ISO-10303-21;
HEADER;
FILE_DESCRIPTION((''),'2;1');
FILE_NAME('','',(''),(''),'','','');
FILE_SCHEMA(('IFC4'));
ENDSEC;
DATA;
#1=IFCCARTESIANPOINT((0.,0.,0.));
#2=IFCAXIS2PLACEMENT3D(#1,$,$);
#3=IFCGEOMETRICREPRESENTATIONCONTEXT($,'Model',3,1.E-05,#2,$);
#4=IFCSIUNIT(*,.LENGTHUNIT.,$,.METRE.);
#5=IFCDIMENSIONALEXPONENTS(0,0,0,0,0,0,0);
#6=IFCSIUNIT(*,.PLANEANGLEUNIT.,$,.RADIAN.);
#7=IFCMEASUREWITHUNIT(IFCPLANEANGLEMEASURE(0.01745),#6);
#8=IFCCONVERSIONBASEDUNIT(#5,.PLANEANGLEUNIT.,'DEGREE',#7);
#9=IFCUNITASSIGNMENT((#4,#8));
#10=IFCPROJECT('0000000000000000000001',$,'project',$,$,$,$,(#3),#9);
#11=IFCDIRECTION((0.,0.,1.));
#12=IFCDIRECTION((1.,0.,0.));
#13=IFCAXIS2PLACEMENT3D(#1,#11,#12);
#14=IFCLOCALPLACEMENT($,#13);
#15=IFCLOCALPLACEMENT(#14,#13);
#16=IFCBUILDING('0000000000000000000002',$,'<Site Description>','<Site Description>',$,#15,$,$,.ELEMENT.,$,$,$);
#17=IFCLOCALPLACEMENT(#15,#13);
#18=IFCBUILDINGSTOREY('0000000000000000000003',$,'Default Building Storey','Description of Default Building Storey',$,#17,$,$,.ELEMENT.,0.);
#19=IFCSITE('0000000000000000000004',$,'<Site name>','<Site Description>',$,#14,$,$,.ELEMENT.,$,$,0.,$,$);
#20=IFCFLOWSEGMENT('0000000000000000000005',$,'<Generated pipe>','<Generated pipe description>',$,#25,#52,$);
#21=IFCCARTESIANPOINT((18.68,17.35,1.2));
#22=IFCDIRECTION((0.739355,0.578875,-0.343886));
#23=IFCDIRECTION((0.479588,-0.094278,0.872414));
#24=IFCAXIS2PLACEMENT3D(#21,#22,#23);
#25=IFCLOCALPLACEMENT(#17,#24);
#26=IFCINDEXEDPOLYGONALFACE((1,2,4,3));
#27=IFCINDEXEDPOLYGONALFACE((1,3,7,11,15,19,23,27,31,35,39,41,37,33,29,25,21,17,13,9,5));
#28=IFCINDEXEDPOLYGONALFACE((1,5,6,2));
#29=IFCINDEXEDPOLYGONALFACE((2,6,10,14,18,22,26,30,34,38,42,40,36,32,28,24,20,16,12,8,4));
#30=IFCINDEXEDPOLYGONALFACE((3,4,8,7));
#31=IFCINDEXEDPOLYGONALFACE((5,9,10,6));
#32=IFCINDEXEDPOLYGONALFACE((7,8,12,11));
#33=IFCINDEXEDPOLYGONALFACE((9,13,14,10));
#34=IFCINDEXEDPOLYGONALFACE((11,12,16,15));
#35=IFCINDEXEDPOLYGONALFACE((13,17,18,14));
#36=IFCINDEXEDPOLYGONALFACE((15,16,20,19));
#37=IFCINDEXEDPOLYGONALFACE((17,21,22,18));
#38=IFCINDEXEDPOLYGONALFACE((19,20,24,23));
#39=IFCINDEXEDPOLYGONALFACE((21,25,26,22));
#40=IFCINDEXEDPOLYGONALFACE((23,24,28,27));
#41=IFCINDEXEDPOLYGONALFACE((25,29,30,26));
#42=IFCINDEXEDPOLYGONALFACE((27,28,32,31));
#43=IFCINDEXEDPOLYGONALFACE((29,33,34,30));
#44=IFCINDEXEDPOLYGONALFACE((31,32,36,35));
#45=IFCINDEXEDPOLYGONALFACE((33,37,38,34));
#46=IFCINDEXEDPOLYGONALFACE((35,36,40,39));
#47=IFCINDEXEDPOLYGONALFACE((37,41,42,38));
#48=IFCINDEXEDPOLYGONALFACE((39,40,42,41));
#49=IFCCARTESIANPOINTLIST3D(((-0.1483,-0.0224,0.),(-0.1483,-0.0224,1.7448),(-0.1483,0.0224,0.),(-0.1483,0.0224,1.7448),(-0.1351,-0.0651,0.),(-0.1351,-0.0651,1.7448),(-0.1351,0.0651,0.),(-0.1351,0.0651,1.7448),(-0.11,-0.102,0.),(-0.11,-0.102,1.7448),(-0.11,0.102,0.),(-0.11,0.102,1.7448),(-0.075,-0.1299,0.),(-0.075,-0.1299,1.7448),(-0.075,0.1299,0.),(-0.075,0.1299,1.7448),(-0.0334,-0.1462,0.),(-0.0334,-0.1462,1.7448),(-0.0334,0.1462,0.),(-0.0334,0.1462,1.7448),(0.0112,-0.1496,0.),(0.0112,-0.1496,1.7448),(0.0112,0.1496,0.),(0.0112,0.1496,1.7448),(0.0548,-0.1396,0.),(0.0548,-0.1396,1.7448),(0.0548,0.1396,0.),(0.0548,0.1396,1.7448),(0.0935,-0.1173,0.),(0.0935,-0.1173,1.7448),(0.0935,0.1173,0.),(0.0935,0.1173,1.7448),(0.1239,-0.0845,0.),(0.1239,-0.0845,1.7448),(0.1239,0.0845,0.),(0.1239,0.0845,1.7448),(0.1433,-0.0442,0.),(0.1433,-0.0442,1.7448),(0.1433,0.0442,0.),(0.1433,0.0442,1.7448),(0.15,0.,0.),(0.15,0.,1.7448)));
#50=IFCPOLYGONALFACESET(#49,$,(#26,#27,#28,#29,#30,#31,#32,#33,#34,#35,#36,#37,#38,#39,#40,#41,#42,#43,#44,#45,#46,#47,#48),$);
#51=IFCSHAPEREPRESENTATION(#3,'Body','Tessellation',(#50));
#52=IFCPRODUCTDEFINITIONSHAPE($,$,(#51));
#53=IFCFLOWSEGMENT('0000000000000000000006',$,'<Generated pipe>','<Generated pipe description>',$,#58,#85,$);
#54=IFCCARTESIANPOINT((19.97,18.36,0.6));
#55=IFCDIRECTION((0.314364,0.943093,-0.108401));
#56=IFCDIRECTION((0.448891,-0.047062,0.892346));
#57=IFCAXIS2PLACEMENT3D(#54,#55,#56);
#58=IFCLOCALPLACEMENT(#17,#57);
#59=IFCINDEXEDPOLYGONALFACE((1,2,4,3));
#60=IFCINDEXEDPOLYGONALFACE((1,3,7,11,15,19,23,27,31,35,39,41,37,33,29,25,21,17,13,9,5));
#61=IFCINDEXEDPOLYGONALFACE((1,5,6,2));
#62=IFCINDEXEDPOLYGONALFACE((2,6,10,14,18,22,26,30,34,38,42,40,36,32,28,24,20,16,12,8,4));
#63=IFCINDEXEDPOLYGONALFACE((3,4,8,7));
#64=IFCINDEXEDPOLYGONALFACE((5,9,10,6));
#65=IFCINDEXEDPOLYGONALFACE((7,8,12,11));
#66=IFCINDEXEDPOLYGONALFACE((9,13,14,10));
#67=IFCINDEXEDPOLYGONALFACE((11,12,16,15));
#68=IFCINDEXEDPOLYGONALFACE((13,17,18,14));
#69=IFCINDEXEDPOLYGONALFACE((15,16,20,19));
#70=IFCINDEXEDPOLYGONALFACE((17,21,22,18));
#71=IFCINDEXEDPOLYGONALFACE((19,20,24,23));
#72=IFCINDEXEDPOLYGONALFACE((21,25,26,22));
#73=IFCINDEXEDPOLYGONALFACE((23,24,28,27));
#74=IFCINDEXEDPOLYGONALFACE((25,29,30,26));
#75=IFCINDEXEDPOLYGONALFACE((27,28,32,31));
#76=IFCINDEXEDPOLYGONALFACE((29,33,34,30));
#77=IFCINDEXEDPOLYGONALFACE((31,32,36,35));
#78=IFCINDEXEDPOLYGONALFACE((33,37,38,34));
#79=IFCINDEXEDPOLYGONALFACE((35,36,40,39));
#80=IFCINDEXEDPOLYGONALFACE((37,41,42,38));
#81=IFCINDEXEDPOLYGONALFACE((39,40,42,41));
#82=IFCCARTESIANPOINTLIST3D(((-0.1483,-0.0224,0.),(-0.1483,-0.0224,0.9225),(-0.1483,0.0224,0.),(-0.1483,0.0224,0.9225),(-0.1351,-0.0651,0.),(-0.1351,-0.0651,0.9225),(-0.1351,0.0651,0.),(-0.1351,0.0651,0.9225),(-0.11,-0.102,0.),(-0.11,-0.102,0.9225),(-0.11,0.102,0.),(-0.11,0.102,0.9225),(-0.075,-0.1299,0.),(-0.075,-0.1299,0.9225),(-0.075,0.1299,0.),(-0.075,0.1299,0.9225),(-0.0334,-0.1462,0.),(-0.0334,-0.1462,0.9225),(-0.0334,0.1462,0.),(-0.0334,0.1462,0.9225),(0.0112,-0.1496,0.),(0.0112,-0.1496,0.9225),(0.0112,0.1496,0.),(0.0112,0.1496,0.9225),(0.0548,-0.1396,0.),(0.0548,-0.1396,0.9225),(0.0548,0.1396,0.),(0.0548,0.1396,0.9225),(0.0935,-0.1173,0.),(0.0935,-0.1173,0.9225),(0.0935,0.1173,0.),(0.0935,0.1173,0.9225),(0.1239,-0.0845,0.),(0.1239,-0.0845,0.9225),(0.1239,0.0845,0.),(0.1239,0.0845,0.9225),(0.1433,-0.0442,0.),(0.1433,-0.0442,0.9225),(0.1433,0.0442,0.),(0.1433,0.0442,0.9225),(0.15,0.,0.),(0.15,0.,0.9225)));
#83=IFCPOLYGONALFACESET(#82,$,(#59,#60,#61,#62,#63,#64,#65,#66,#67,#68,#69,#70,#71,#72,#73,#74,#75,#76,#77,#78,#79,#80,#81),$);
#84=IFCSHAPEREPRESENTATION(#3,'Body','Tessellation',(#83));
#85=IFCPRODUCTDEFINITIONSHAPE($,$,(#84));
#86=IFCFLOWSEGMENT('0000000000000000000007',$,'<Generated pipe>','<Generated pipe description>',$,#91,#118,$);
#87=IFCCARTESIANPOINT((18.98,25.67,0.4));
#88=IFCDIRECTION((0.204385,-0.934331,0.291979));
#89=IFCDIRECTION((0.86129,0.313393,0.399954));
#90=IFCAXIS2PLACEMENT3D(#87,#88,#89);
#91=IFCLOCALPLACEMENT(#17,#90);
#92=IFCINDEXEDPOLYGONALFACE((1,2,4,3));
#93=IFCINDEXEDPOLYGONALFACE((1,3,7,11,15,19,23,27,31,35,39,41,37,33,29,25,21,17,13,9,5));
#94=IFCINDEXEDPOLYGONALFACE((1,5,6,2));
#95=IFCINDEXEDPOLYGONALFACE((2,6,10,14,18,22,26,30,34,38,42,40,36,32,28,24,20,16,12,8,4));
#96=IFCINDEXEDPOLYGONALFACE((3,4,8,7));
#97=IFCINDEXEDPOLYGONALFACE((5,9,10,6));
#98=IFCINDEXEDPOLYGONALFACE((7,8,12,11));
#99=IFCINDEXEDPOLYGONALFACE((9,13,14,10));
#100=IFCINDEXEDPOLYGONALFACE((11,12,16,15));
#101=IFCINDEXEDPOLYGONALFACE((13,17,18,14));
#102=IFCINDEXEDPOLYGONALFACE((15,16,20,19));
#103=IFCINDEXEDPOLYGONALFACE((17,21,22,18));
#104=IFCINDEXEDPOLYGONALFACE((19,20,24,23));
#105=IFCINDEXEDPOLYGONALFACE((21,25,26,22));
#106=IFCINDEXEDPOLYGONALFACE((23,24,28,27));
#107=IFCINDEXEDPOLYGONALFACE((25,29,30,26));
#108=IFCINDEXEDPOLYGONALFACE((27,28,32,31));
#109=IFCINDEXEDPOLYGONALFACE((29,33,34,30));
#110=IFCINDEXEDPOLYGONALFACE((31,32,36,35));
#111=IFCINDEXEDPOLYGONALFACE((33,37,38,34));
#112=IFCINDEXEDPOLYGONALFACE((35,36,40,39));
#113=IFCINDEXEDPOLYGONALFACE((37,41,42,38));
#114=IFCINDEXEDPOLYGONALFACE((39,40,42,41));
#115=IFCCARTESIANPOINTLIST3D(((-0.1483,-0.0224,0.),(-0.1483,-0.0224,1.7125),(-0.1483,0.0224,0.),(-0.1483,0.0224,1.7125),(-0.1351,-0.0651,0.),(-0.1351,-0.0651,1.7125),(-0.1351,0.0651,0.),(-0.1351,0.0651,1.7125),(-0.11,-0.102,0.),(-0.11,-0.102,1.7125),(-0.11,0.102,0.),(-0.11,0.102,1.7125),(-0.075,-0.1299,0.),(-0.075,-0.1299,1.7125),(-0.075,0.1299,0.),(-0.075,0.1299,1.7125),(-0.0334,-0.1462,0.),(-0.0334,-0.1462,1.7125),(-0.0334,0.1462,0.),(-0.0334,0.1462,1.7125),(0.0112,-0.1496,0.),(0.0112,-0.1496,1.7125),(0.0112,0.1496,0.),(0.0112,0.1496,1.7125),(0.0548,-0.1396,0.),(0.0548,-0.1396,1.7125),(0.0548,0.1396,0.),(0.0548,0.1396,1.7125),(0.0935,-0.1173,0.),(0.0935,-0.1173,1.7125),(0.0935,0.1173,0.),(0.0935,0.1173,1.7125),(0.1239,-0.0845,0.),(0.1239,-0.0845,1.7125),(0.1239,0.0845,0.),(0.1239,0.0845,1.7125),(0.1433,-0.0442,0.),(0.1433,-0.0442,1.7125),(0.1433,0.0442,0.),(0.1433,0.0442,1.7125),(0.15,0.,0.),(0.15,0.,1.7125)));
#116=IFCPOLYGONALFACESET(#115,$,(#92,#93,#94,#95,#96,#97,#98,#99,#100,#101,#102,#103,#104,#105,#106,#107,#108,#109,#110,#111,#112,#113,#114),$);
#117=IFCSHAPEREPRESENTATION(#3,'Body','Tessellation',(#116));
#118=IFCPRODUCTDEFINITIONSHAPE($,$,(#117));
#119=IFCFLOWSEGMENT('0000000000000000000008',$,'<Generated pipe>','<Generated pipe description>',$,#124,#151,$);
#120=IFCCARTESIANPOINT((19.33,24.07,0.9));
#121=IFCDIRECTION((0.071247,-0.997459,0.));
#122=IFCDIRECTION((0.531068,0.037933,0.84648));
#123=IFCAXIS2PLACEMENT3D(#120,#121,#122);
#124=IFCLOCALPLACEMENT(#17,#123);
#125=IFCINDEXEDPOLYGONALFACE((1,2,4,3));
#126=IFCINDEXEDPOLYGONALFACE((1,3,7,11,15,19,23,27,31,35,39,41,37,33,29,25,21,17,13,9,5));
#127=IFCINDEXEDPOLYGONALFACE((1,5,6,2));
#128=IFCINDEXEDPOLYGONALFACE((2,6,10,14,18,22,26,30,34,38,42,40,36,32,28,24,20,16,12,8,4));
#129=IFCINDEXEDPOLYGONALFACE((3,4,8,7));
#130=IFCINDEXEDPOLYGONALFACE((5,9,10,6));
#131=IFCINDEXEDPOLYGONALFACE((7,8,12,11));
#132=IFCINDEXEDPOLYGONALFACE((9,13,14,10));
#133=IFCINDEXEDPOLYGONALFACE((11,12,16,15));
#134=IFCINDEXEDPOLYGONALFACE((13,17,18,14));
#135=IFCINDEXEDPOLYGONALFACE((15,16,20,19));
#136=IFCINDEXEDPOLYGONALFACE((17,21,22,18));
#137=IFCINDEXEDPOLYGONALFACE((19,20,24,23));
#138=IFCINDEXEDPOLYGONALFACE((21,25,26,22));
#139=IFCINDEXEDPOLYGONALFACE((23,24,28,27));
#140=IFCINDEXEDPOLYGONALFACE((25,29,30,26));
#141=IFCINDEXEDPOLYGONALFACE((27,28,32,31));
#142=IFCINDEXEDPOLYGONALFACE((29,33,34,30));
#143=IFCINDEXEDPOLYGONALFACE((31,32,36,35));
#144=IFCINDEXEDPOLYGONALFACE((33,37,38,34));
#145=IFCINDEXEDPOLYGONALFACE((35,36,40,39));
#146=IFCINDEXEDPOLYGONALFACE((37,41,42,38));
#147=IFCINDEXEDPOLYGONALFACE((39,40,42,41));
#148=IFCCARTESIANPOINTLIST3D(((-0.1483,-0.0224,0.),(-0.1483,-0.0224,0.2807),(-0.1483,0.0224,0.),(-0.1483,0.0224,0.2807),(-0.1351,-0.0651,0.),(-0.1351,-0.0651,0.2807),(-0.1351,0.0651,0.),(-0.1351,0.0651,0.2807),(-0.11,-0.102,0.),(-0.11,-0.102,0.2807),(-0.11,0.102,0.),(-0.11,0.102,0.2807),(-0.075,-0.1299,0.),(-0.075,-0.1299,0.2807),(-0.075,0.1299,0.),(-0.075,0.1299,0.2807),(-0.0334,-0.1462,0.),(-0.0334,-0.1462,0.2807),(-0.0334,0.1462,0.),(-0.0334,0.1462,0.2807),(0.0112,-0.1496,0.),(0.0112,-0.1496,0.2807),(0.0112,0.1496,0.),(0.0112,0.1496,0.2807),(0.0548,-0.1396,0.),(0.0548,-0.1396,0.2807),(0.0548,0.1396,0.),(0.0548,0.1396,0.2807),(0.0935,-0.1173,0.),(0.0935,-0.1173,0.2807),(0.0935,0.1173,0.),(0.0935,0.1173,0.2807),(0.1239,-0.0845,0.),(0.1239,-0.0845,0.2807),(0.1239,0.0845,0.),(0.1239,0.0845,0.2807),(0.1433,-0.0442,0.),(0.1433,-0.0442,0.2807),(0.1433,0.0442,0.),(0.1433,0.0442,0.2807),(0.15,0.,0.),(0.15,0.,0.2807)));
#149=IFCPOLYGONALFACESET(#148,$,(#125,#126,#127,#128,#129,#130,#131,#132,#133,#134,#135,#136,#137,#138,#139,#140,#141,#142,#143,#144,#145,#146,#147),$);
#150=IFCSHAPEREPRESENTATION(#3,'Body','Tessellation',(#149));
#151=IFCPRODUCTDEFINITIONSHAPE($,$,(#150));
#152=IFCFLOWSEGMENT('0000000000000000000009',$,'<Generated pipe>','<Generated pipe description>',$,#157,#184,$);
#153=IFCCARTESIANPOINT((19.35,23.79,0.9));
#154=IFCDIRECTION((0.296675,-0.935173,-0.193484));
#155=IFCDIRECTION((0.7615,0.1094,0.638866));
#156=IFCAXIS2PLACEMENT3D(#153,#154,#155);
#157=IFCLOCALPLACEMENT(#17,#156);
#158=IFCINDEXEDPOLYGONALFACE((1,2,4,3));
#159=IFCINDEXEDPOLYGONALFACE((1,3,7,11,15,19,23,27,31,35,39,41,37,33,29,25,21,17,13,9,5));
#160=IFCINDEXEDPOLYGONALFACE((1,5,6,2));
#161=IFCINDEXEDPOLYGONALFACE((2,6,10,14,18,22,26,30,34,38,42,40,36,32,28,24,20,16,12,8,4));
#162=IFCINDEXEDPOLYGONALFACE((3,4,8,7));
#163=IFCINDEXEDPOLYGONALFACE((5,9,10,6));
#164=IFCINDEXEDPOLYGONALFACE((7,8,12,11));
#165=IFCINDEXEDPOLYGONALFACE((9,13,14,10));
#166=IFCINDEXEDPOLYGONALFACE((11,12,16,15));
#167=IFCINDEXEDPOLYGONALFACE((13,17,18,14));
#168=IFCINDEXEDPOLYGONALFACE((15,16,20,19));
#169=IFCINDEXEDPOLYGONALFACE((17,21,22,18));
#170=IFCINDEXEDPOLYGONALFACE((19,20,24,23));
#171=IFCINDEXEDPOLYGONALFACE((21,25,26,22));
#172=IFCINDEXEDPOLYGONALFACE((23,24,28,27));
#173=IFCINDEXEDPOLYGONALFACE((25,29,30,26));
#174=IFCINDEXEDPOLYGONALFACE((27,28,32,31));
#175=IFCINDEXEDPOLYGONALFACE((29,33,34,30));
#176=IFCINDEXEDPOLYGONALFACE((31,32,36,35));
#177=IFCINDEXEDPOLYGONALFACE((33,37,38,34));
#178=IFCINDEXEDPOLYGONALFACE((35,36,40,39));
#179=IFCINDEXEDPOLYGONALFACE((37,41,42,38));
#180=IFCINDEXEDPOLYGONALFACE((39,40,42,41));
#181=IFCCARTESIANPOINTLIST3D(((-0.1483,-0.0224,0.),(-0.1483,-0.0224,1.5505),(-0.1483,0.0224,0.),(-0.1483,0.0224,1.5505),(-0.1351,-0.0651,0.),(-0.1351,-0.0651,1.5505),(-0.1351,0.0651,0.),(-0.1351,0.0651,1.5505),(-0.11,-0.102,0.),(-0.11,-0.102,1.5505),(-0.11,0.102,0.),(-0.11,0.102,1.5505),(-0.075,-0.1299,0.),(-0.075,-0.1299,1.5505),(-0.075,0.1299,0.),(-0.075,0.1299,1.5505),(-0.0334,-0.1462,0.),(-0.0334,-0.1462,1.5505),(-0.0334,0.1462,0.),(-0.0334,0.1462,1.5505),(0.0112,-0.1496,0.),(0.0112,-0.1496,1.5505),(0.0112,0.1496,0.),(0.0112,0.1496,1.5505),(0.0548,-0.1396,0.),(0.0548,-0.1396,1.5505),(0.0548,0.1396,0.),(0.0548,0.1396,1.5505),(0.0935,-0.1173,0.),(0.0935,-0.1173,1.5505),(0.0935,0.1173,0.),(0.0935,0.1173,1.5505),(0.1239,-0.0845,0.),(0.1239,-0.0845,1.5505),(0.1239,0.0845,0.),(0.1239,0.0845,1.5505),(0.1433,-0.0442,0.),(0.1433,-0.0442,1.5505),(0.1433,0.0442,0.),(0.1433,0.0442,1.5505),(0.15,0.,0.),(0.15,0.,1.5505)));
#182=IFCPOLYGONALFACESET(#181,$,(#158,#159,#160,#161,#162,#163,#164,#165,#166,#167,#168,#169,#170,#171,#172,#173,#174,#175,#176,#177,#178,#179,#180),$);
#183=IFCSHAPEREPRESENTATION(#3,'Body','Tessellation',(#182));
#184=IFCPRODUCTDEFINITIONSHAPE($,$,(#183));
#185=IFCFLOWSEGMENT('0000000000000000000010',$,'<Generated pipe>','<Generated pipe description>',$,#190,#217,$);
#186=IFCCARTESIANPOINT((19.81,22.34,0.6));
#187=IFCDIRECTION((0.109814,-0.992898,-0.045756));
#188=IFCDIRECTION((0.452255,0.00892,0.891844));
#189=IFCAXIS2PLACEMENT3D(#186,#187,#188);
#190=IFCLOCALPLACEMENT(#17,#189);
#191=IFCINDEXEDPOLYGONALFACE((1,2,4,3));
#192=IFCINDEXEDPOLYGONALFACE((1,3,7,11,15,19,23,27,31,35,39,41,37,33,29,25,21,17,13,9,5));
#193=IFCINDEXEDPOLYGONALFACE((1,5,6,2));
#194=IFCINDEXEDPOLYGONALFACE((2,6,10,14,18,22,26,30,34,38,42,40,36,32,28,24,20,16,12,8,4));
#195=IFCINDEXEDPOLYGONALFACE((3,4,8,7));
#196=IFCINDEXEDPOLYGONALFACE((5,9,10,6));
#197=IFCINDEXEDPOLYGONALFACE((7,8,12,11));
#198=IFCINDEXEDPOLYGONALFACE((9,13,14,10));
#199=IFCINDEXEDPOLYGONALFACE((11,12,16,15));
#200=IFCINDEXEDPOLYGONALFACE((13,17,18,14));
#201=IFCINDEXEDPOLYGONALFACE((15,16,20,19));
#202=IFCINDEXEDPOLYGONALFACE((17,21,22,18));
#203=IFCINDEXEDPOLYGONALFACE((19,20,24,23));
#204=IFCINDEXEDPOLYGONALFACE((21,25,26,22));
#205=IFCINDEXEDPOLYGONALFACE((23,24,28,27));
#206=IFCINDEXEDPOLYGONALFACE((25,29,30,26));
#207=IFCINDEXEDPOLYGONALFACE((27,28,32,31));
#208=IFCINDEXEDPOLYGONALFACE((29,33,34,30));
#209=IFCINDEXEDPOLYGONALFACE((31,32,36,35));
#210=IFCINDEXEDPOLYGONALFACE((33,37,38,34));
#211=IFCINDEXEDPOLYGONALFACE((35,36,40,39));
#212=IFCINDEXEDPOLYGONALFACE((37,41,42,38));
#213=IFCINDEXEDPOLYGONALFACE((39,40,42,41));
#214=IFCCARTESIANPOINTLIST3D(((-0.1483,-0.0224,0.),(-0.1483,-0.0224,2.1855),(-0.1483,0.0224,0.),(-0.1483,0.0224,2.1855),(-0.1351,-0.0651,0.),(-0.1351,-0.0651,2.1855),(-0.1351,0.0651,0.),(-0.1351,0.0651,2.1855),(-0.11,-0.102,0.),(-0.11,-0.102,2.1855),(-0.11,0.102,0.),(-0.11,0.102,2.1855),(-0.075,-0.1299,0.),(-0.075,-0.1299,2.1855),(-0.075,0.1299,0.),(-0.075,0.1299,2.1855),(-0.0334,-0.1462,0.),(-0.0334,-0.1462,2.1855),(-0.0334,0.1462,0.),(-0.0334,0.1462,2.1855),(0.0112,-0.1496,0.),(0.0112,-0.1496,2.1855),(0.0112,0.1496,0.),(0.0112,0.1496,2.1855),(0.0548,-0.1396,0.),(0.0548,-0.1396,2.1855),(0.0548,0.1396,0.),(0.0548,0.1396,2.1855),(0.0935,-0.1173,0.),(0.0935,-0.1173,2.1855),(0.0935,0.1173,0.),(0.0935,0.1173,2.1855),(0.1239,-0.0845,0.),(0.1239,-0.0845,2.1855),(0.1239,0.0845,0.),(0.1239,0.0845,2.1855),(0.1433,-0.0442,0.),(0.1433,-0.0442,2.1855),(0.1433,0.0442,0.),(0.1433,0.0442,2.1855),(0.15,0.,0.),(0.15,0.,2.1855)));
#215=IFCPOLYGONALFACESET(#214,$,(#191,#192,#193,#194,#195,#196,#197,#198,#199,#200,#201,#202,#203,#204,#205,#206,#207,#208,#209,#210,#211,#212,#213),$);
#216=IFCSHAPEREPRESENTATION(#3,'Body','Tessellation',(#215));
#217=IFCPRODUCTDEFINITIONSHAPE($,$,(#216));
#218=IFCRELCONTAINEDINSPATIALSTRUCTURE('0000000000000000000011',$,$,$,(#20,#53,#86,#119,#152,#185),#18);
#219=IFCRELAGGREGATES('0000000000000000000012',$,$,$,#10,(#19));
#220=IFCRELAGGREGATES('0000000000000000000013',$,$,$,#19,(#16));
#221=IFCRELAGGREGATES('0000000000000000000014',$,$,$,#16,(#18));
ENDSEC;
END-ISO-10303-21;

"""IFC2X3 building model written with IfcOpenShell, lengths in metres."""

from ifc_helpers import new_model, entity, si_unit, converted_unit, frame, origin, origin_with_axes, origin_2d_with_axis, place, context, project, spatial, circle, extrude, element, save


model = new_model("IFC2X3")

# Units and contexts
model_context = context("Model", 3, precision=1e-05, world=origin())
ifc_project = project(units=[si_unit("LENGTHUNIT", "METRE"), converted_unit("PLANEANGLEUNIT", "DEGREE", entity("IfcPlaneAngleMeasure", 0.01745), si_unit("PLANEANGLEUNIT", "RADIAN"), dimensions=[0, 0, 0, 0, 0, 0, 0])], contexts=[model_context])

# Site, building, storey
site_placement = place(None, origin_with_axes())
site = spatial("IfcSite", under=ifc_project, at=site_placement, Name="<Site name>", Description="<Site Description>", CompositionType="ELEMENT", RefElevation=0.0)
building_placement = place(site_placement, origin_with_axes())
building = spatial("IfcBuilding", under=site, at=building_placement, Name="<Site Description>", Description="<Site Description>", CompositionType="ELEMENT")
storey_placement = place(building_placement, origin_with_axes())
storey = spatial("IfcBuildingStorey", under=building, at=storey_placement, Name="Default Building Storey", Description="Description of Default Building Storey", CompositionType="ELEMENT", Elevation=0.0)

# Flow segments
flow_segment_1_placement = place(storey_placement, frame((18.68, 17.35, 1.2), z_axis=(0.739355, 0.578875, -0.343886), x_axis=(0.479588, -0.094278, 0.872414)))
element("IfcFlowSegment", 1, at=flow_segment_1_placement, inside=storey, Name="<Generated pipe>", Description="<Generated pipe description>", context=model_context, shape_type="SweptSolid", body=[
    extrude(circle(Radius=0.15, at=origin_2d_with_axis()), origin_with_axes(), (0.0, 0.0, 1.0), 1.7448),
])
flow_segment_2_placement = place(storey_placement, frame((19.97, 18.36, 0.6), z_axis=(0.314364, 0.943093, -0.108401), x_axis=(0.448891, -0.047062, 0.892346)))
element("IfcFlowSegment", 2, at=flow_segment_2_placement, inside=storey, Name="<Generated pipe>", Description="<Generated pipe description>", context=model_context, shape_type="SweptSolid", body=[
    extrude(circle(Radius=0.15, at=origin_2d_with_axis()), origin_with_axes(), (0.0, 0.0, 1.0), 0.9225),
])
flow_segment_3_placement = place(storey_placement, frame((18.98, 25.67, 0.4), z_axis=(0.204385, -0.934331, 0.291979), x_axis=(0.86129, 0.313393, 0.399954)))
element("IfcFlowSegment", 3, at=flow_segment_3_placement, inside=storey, Name="<Generated pipe>", Description="<Generated pipe description>", context=model_context, shape_type="SweptSolid", body=[
    extrude(circle(Radius=0.15, at=origin_2d_with_axis()), origin_with_axes(), (0.0, 0.0, 1.0), 1.7125),
])
flow_segment_4_placement = place(storey_placement, frame((19.33, 24.07, 0.9), z_axis=(0.071247, -0.997459, 0.0), x_axis=(0.531068, 0.037933, 0.84648)))
element("IfcFlowSegment", 4, at=flow_segment_4_placement, inside=storey, Name="<Generated pipe>", Description="<Generated pipe description>", context=model_context, shape_type="SweptSolid", body=[
    extrude(circle(Radius=0.15, at=origin_2d_with_axis()), origin_with_axes(), (0.0, 0.0, 1.0), 0.2807),
])
flow_segment_5_placement = place(storey_placement, frame((19.35, 23.79, 0.9), z_axis=(0.296675, -0.935173, -0.193484), x_axis=(0.7615, 0.1094, 0.638866)))
element("IfcFlowSegment", 5, at=flow_segment_5_placement, inside=storey, Name="<Generated pipe>", Description="<Generated pipe description>", context=model_context, shape_type="SweptSolid", body=[
    extrude(circle(Radius=0.15, at=origin_2d_with_axis()), origin_with_axes(), (0.0, 0.0, 1.0), 1.5505),
])
flow_segment_6_placement = place(storey_placement, frame((19.81, 22.34, 0.6), z_axis=(0.109814, -0.992898, -0.045756), x_axis=(0.452255, 0.00892, 0.891844)))
element("IfcFlowSegment", 6, at=flow_segment_6_placement, inside=storey, Name="<Generated pipe>", Description="<Generated pipe description>", context=model_context, shape_type="SweptSolid", body=[
    extrude(circle(Radius=0.15, at=origin_2d_with_axis()), origin_with_axes(), (0.0, 0.0, 1.0), 2.1855),
])

save(model, "model.ifc")
